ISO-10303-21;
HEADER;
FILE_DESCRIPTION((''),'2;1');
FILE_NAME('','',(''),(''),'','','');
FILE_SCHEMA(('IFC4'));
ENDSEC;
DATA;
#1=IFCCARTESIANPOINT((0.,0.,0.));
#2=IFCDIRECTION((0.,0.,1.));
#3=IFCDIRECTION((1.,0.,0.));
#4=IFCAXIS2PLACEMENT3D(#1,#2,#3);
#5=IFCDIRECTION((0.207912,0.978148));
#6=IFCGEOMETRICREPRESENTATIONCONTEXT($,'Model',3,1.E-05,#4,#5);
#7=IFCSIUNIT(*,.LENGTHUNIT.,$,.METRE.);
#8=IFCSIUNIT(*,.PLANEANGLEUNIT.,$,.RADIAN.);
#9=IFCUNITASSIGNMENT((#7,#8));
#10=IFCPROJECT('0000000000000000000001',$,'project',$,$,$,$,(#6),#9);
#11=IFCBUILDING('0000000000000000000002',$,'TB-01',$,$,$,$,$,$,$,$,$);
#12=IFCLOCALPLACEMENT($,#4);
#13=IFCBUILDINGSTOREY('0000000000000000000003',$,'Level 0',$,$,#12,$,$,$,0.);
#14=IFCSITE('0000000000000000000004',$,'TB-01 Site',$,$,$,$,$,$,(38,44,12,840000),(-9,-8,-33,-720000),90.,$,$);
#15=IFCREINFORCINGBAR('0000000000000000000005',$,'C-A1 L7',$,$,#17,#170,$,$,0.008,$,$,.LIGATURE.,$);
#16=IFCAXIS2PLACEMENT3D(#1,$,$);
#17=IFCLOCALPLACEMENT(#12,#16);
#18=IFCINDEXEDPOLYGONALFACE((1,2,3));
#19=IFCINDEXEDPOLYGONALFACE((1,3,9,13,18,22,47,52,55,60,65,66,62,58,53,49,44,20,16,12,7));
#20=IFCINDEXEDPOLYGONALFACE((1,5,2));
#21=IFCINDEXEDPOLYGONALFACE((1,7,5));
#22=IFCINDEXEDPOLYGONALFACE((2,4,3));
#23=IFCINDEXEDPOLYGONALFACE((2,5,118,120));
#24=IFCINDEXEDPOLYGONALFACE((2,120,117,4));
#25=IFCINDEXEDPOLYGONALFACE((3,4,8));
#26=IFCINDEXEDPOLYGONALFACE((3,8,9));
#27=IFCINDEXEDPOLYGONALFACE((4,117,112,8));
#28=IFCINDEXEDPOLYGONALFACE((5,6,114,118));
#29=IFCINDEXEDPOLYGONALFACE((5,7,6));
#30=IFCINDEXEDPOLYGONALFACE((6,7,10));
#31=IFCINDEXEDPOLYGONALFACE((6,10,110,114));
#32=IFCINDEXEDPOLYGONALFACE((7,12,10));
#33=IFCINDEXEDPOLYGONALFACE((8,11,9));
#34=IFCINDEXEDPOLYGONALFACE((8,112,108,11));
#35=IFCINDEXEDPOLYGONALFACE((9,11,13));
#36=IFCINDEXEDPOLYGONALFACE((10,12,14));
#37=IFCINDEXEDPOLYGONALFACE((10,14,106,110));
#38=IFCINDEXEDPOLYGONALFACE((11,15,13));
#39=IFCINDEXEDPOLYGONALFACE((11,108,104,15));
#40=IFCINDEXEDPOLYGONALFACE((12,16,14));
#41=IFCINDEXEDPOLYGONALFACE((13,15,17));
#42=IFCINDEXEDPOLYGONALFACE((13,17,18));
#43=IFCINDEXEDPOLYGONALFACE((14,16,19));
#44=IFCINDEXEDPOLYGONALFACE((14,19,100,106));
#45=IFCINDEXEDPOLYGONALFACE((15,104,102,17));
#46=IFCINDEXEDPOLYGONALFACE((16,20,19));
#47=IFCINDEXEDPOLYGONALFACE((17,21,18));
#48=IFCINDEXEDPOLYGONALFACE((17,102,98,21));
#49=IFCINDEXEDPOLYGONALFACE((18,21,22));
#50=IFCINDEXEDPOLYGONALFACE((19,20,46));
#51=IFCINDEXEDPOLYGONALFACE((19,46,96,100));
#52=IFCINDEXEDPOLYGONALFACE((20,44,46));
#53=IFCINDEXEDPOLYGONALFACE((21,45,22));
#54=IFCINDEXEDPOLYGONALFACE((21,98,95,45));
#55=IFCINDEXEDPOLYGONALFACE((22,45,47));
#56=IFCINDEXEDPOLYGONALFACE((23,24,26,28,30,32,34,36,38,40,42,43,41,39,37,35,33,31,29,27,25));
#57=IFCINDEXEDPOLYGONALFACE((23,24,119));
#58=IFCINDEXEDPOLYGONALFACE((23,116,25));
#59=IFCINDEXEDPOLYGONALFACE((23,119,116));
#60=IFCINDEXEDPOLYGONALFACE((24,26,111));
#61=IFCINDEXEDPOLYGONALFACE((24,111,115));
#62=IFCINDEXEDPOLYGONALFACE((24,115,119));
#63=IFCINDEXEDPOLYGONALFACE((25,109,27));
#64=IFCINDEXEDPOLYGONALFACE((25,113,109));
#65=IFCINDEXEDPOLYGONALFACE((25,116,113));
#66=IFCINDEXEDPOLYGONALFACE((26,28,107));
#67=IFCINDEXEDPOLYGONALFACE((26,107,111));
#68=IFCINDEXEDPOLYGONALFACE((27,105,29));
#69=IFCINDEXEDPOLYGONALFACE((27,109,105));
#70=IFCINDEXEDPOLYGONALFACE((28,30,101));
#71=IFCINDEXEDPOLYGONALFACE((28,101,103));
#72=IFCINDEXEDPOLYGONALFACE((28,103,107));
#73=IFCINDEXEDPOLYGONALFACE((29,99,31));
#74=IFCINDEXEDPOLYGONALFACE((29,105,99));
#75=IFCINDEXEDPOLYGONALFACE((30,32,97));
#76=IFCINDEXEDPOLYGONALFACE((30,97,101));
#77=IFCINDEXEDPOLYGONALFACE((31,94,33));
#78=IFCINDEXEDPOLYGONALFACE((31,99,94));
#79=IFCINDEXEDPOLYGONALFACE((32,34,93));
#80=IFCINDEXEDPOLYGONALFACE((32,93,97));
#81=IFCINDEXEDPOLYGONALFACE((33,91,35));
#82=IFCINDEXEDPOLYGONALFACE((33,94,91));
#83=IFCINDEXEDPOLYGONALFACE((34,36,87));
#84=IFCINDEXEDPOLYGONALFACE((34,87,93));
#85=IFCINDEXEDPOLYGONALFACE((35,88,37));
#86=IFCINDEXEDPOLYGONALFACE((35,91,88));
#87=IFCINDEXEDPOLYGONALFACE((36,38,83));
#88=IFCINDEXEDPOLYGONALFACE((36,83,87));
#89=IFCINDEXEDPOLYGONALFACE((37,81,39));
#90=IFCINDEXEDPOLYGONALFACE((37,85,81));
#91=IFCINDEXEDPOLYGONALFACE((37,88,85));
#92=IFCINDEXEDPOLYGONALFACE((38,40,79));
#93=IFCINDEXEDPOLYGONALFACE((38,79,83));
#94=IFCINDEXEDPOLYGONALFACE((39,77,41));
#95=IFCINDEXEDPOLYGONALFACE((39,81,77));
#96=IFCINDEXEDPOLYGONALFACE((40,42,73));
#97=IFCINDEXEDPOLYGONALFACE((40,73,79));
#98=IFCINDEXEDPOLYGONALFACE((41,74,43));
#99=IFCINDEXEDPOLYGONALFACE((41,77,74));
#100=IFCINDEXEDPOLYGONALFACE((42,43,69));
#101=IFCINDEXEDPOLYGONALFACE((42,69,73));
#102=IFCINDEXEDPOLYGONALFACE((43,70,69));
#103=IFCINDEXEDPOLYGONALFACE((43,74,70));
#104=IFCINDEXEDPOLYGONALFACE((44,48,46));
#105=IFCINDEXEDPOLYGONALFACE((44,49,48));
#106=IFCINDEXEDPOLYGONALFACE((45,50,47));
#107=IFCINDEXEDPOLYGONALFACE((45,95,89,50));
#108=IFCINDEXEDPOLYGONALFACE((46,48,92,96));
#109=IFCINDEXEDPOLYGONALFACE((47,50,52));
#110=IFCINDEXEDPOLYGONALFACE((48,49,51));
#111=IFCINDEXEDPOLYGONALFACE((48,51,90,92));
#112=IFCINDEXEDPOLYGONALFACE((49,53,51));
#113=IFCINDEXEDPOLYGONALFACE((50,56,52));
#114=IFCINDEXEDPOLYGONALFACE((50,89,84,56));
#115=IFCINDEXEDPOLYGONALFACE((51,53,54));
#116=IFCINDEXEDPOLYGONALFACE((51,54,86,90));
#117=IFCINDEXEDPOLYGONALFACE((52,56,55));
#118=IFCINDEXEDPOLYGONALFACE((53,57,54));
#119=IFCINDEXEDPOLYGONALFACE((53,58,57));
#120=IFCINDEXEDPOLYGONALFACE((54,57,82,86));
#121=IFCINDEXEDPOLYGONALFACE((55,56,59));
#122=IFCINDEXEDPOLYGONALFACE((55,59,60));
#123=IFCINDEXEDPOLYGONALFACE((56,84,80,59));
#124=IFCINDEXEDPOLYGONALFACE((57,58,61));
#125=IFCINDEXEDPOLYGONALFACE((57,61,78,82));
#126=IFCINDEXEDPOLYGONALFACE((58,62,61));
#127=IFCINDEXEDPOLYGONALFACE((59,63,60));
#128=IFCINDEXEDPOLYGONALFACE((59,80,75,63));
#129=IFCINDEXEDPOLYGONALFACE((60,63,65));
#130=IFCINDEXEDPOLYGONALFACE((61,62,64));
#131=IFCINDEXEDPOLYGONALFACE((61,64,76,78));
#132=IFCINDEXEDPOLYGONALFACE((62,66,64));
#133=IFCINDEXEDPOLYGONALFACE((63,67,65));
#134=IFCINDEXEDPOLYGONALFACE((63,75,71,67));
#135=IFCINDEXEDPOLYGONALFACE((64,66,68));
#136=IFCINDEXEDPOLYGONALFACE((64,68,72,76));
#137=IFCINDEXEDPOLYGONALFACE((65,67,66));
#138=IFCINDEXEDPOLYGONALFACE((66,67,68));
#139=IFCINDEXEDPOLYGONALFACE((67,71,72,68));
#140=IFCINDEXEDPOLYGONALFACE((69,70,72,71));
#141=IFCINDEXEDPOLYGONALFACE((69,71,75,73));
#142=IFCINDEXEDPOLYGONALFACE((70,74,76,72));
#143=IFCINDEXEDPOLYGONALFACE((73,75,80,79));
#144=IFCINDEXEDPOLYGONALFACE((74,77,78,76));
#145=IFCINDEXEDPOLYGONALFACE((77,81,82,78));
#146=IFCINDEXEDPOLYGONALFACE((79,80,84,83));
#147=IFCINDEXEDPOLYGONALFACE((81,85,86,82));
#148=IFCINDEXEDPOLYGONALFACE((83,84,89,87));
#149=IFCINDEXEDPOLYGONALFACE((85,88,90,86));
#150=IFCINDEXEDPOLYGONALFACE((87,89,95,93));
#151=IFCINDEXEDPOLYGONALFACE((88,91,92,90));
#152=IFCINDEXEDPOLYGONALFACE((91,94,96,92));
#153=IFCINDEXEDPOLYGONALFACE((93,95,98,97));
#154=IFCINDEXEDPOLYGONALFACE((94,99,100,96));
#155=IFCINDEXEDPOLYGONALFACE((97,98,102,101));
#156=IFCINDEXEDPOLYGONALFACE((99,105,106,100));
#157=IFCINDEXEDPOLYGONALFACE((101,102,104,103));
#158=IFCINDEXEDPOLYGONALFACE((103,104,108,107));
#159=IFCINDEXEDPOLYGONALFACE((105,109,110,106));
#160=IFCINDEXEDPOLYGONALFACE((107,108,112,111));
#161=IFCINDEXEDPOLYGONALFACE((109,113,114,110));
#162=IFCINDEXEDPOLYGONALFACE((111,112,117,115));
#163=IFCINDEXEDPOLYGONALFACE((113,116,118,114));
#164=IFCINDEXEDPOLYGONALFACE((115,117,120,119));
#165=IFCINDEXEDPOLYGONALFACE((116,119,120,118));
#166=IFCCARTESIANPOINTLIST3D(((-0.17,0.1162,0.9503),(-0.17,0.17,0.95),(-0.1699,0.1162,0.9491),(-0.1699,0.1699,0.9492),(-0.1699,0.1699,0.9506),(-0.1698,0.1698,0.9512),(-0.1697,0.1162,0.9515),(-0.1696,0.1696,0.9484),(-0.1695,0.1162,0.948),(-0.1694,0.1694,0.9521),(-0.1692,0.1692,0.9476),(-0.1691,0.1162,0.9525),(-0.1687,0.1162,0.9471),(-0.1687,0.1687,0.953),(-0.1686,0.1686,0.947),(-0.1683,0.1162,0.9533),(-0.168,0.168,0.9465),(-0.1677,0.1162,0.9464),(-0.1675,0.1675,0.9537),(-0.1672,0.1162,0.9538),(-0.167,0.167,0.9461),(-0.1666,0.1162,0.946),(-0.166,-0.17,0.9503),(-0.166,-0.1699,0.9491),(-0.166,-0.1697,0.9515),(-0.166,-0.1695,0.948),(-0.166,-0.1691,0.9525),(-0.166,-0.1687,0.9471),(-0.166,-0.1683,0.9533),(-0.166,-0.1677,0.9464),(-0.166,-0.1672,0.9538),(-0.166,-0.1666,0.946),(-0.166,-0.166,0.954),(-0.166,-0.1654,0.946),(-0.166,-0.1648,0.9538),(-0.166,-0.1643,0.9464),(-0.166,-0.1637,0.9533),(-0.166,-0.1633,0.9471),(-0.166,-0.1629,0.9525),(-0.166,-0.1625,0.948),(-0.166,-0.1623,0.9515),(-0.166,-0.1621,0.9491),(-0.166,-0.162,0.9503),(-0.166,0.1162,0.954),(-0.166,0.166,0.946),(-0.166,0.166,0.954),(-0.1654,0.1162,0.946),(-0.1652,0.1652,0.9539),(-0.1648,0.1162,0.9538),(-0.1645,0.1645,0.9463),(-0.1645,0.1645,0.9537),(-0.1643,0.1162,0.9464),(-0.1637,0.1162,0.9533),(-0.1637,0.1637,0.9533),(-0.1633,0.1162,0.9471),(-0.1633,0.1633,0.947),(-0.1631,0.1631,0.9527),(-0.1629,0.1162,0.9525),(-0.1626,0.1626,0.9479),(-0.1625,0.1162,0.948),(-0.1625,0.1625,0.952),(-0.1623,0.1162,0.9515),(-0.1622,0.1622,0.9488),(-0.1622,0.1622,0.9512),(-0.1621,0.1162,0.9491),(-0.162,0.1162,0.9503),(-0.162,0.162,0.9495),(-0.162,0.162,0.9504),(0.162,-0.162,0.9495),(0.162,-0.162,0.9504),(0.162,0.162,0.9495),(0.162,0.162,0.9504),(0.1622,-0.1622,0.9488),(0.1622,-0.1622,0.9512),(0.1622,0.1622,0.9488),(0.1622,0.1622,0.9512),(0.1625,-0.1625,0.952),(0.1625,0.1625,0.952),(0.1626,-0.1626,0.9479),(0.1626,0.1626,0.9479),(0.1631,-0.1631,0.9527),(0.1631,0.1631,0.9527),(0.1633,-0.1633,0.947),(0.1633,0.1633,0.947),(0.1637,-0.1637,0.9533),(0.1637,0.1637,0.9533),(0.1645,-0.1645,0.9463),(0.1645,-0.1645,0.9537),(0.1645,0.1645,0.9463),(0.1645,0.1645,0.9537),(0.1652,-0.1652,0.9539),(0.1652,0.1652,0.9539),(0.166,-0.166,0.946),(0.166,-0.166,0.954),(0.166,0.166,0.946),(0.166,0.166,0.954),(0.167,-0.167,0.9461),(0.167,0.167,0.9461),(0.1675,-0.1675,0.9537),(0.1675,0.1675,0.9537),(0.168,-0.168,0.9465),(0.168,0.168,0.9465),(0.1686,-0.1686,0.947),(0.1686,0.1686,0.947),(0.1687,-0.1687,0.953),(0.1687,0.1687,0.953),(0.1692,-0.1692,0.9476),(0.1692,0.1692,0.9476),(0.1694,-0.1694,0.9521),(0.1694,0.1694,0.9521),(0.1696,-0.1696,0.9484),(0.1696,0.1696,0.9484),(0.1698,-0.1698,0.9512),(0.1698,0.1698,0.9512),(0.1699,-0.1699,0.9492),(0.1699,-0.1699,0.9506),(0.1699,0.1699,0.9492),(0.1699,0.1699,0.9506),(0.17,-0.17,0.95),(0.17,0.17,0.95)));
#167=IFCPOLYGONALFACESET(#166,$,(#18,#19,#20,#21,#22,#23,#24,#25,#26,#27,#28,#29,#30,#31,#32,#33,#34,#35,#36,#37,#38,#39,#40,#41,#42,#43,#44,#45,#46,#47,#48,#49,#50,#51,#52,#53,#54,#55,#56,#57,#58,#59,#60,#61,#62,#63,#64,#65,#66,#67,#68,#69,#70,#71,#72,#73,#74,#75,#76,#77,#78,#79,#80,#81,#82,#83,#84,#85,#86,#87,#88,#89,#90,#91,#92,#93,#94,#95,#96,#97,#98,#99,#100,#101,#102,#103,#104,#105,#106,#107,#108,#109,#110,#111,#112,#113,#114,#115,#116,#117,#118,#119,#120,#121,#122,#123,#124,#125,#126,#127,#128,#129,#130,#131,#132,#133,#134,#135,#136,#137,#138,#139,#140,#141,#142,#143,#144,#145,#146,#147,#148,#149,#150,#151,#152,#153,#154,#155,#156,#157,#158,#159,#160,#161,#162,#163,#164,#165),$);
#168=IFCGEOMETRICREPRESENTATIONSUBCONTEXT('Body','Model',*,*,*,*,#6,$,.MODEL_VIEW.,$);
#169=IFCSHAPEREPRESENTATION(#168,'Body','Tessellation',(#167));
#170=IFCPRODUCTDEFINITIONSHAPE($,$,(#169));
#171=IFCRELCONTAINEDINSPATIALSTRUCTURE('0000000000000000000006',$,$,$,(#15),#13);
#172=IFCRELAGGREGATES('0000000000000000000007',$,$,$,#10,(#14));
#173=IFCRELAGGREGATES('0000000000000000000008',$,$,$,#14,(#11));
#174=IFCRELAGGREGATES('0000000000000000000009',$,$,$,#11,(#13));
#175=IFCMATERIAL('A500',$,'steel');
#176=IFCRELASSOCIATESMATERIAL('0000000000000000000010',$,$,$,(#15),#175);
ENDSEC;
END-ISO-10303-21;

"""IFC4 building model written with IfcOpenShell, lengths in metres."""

from ifc_helpers import new_model, entity, si_unit, direction, origin_with_axes, place, context, subcontext, project, spatial, material, element, save


model = new_model("IFC4")

# Units and contexts
model_context = context("Model", 3, precision=1e-05, world=origin_with_axes(), true_north=direction((0.207912, 0.978148)))
body_context = subcontext(model_context, "Body", "Model", "MODEL_VIEW")
ifc_project = project(units=[si_unit("LENGTHUNIT", "METRE"), si_unit("PLANEANGLEUNIT", "RADIAN")], contexts=[model_context])

# Site, building, storey
site = spatial("IfcSite", under=ifc_project, Name="TB-01 Site", RefLatitude=(38, 44, 12, 840000), RefLongitude=(-9, -8, -33, -720000), RefElevation=90.0)
building = spatial("IfcBuilding", under=site, Name="TB-01")
storey_placement = place(None, origin_with_axes())
storey = spatial("IfcBuildingStorey", under=building, at=storey_placement, Name="Level 0", Elevation=0.0)

# Reinforcing bar
ifc_material_1 = material(Name="A500", Category="steel")
reinforcing_bar_1_placement = place(storey_placement, origin_with_axes())
element("IfcReinforcingBar", 1, at=reinforcing_bar_1_placement, inside=storey, material=ifc_material_1, Name="C-A1 L7", NominalDiameter=0.008, PredefinedType="LIGATURE", context=body_context, shape_type="AdvancedSweptSolid", body=[
    entity("IfcSweptDiskSolid", entity("IfcPolyline", [entity("IfcCartesianPoint", [-0.166, -0.166, 0.95]), entity("IfcCartesianPoint", [0.166, -0.166, 0.95]), entity("IfcCartesianPoint", [0.166, 0.166, 0.95]), entity("IfcCartesianPoint", [-0.166, 0.166, 0.95]), entity("IfcCartesianPoint", [-0.166, 0.1162, 0.95])]), 0.004),
])

save(model, "model.ifc")
